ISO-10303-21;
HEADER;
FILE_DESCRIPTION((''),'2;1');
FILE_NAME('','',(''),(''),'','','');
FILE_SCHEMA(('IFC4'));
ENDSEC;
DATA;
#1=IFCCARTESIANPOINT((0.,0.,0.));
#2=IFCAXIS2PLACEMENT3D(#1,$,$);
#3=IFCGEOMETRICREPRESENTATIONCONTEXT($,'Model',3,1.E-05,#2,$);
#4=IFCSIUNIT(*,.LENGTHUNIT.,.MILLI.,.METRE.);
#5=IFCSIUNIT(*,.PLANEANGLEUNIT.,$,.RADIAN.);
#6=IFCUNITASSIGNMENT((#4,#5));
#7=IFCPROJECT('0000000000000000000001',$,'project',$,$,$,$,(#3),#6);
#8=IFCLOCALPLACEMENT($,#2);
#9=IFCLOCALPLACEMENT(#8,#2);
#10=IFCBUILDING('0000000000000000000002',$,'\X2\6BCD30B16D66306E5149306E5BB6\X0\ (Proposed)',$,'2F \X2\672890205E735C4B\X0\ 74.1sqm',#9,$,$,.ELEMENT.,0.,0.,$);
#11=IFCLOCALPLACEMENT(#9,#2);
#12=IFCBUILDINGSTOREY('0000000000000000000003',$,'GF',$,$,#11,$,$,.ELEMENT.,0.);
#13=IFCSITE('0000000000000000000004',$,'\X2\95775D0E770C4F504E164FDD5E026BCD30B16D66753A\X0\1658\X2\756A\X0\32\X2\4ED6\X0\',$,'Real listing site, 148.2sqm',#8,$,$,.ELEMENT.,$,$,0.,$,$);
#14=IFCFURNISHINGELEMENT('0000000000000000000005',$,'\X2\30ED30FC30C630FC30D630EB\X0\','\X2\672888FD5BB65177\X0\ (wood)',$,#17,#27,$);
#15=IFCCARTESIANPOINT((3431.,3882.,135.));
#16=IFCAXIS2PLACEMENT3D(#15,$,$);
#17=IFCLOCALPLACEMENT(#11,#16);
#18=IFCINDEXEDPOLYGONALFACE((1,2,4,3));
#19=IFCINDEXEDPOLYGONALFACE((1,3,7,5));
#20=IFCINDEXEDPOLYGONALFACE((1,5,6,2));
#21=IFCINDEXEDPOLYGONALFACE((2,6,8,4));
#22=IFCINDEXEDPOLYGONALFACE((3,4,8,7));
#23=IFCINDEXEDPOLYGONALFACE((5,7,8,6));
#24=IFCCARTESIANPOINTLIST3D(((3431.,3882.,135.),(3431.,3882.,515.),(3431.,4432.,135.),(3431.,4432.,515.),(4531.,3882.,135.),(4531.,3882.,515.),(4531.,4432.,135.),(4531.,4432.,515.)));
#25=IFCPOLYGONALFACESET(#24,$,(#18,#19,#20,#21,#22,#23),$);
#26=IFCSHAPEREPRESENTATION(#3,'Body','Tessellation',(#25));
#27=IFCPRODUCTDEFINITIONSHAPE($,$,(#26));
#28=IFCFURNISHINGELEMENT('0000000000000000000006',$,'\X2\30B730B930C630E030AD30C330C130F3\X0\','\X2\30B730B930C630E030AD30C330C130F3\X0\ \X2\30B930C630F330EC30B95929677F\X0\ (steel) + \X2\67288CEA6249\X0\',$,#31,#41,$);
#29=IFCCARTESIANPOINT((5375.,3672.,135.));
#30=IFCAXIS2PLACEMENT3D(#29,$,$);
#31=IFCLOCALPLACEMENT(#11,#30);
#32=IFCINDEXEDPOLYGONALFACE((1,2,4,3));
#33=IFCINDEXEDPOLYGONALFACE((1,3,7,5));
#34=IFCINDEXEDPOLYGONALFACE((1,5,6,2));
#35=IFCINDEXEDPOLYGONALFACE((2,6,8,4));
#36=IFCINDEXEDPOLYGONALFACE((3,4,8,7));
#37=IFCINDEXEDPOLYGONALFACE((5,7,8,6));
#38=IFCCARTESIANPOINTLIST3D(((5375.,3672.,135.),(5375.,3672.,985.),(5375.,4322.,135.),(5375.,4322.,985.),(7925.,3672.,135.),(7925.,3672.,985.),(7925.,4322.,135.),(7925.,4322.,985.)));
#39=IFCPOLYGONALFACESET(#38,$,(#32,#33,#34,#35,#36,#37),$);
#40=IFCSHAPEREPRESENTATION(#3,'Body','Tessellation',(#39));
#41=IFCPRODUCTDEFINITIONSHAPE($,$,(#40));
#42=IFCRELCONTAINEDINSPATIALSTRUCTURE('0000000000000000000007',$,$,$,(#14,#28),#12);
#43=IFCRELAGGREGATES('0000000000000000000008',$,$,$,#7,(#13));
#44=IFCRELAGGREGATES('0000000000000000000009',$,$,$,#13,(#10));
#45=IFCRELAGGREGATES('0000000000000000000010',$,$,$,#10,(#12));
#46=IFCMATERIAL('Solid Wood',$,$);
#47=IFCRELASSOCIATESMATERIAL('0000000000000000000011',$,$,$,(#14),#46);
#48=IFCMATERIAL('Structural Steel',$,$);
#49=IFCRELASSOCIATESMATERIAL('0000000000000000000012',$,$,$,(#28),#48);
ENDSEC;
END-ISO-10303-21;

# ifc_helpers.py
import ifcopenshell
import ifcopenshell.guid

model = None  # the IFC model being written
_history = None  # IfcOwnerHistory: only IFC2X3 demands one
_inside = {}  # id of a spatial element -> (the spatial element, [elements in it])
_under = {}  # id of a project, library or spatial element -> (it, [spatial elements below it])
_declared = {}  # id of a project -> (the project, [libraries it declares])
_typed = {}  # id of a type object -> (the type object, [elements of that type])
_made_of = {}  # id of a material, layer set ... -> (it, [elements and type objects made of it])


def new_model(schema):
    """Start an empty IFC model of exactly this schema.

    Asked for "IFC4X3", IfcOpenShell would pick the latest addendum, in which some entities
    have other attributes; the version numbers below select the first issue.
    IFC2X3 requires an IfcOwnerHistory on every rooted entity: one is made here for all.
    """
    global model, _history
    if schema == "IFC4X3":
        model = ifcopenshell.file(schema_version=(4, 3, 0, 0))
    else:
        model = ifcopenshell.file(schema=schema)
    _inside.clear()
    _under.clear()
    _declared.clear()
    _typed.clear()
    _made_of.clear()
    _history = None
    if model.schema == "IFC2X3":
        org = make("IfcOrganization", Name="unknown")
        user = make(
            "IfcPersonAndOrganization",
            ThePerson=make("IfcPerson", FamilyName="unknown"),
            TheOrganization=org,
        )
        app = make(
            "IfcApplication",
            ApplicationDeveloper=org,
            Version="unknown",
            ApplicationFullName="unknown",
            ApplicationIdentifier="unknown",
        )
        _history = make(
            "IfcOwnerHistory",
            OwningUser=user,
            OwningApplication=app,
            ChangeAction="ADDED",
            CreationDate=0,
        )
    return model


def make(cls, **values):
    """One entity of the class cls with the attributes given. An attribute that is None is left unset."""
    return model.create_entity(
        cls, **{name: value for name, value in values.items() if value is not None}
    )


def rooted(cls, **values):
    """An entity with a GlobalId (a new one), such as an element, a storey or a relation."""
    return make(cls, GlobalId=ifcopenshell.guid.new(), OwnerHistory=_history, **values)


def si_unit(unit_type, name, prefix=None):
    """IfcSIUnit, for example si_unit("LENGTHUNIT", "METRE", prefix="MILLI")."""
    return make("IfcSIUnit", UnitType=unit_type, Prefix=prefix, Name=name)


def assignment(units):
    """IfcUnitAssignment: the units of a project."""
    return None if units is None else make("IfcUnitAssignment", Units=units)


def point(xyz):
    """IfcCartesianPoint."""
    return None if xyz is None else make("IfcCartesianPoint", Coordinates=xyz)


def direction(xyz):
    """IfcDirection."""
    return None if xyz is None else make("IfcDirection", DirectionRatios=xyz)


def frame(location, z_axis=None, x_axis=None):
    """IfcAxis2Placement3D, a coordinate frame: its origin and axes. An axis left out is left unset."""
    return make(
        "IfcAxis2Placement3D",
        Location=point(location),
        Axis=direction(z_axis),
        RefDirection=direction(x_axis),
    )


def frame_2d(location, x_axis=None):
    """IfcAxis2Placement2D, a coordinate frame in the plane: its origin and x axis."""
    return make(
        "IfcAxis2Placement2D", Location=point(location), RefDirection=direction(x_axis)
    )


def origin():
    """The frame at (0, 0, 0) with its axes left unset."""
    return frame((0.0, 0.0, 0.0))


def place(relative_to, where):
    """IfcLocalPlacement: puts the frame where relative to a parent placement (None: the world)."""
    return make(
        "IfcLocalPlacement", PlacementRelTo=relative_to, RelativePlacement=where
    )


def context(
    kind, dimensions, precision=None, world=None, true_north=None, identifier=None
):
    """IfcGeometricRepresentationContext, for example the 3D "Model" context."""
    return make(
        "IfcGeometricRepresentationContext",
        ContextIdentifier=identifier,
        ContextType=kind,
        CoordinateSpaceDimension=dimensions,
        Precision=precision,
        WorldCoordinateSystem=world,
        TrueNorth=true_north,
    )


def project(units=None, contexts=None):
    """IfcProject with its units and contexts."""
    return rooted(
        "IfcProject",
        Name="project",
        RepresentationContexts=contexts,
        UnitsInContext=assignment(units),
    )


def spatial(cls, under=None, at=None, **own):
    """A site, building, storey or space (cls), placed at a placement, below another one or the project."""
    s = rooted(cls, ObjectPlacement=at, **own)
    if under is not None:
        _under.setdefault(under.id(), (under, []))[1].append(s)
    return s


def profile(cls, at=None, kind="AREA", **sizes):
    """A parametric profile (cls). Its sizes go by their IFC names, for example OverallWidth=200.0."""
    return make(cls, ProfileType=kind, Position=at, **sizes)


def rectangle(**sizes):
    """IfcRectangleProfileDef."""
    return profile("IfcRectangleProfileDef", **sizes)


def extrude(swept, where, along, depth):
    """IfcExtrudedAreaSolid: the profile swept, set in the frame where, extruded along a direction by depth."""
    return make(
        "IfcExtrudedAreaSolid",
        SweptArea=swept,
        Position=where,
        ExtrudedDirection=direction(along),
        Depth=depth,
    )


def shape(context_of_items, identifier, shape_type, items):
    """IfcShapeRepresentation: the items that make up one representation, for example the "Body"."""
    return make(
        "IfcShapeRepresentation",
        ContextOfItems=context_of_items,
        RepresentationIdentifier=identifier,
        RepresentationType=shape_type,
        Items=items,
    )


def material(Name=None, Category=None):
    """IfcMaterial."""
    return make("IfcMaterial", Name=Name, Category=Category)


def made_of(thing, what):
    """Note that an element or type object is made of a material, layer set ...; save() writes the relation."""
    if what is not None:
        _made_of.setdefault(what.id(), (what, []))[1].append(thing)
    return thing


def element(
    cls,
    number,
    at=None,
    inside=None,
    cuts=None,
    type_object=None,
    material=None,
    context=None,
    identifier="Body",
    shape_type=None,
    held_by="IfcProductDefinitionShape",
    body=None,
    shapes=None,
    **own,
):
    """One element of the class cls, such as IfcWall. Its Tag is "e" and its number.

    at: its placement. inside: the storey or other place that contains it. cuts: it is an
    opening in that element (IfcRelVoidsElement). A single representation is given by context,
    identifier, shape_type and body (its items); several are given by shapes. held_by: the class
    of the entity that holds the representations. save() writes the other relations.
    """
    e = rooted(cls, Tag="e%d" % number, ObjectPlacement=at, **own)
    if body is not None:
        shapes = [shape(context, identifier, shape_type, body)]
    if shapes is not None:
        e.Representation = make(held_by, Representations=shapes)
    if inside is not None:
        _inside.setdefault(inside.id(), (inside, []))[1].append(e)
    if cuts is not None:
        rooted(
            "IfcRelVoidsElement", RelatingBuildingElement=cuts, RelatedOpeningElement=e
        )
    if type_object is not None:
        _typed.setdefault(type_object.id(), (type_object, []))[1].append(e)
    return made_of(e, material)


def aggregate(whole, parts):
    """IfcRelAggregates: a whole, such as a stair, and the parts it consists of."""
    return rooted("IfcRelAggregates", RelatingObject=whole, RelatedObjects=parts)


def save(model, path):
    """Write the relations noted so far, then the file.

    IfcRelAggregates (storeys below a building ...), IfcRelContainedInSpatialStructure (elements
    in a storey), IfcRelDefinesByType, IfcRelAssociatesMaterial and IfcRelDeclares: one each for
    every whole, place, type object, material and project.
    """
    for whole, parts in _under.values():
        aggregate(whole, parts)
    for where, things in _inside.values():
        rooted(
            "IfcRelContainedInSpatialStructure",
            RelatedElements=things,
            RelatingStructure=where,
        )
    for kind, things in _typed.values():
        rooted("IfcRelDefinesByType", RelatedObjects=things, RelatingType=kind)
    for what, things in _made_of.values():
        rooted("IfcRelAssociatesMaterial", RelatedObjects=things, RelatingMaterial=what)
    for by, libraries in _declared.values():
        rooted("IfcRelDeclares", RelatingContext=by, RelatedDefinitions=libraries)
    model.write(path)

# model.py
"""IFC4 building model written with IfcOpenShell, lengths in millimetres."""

from ifc_helpers import new_model, si_unit, frame, frame_2d, origin, place, context, project, spatial, rectangle, extrude, material, element, save


model = new_model("IFC4")

# Units and contexts
model_context = context("Model", 3, precision=1e-05, world=origin())
ifc_project = project(units=[si_unit("LENGTHUNIT", "METRE", prefix="MILLI"), si_unit("PLANEANGLEUNIT", "RADIAN")], contexts=[model_context])

# Site, building, storey
site_placement = place(None, origin())
site = spatial("IfcSite", under=ifc_project, at=site_placement, Name="長崎県佐世保市母ケ浦町1658番32他", ObjectType="Real listing site, 148.2sqm", CompositionType="ELEMENT", RefElevation=0.0)
building_placement = place(site_placement, origin())
building = spatial("IfcBuilding", under=site, at=building_placement, Name="母ケ浦の光の家 (Proposed)", ObjectType="2F 木造平屋 74.1sqm", CompositionType="ELEMENT", ElevationOfRefHeight=0.0, ElevationOfTerrain=0.0)
storey_placement = place(building_placement, origin())
storey = spatial("IfcBuildingStorey", under=building, at=storey_placement, Name="GF", CompositionType="ELEMENT", Elevation=0.0)

# Shared definitions
ifc_material_1 = material(Name="Solid Wood")

# Furnishing elements
furnishing_1_placement = place(storey_placement, frame((3431.0, 3882.0, 135.0)))
element("IfcFurnishingElement", 1, at=furnishing_1_placement, inside=storey, material=ifc_material_1, Name="ローテーブル", Description="木製家具 (wood)", context=model_context, shape_type="SweptSolid", body=[
    extrude(rectangle(XDim=1100.0, YDim=550.0, at=frame_2d((550.0, 275.0))), frame((3431.0, 3882.0, 135.0)), (0.0, 0.0, 1.0), 380.0),
])
ifc_material_2 = material(Name="Structural Steel")
furnishing_2_placement = place(storey_placement, frame((5375.0, 3672.0, 135.0)))
element("IfcFurnishingElement", 2, at=furnishing_2_placement, inside=storey, material=ifc_material_2, Name="システムキッチン", Description="システムキッチン ステンレス天板 (steel) + 木質扉", context=model_context, shape_type="SweptSolid", body=[
    extrude(rectangle(XDim=2550.0, YDim=650.0, at=frame_2d((1275.0, 325.0))), frame((5375.0, 3672.0, 135.0)), (0.0, 0.0, 1.0), 850.0),
])

save(model, "model.ifc")
